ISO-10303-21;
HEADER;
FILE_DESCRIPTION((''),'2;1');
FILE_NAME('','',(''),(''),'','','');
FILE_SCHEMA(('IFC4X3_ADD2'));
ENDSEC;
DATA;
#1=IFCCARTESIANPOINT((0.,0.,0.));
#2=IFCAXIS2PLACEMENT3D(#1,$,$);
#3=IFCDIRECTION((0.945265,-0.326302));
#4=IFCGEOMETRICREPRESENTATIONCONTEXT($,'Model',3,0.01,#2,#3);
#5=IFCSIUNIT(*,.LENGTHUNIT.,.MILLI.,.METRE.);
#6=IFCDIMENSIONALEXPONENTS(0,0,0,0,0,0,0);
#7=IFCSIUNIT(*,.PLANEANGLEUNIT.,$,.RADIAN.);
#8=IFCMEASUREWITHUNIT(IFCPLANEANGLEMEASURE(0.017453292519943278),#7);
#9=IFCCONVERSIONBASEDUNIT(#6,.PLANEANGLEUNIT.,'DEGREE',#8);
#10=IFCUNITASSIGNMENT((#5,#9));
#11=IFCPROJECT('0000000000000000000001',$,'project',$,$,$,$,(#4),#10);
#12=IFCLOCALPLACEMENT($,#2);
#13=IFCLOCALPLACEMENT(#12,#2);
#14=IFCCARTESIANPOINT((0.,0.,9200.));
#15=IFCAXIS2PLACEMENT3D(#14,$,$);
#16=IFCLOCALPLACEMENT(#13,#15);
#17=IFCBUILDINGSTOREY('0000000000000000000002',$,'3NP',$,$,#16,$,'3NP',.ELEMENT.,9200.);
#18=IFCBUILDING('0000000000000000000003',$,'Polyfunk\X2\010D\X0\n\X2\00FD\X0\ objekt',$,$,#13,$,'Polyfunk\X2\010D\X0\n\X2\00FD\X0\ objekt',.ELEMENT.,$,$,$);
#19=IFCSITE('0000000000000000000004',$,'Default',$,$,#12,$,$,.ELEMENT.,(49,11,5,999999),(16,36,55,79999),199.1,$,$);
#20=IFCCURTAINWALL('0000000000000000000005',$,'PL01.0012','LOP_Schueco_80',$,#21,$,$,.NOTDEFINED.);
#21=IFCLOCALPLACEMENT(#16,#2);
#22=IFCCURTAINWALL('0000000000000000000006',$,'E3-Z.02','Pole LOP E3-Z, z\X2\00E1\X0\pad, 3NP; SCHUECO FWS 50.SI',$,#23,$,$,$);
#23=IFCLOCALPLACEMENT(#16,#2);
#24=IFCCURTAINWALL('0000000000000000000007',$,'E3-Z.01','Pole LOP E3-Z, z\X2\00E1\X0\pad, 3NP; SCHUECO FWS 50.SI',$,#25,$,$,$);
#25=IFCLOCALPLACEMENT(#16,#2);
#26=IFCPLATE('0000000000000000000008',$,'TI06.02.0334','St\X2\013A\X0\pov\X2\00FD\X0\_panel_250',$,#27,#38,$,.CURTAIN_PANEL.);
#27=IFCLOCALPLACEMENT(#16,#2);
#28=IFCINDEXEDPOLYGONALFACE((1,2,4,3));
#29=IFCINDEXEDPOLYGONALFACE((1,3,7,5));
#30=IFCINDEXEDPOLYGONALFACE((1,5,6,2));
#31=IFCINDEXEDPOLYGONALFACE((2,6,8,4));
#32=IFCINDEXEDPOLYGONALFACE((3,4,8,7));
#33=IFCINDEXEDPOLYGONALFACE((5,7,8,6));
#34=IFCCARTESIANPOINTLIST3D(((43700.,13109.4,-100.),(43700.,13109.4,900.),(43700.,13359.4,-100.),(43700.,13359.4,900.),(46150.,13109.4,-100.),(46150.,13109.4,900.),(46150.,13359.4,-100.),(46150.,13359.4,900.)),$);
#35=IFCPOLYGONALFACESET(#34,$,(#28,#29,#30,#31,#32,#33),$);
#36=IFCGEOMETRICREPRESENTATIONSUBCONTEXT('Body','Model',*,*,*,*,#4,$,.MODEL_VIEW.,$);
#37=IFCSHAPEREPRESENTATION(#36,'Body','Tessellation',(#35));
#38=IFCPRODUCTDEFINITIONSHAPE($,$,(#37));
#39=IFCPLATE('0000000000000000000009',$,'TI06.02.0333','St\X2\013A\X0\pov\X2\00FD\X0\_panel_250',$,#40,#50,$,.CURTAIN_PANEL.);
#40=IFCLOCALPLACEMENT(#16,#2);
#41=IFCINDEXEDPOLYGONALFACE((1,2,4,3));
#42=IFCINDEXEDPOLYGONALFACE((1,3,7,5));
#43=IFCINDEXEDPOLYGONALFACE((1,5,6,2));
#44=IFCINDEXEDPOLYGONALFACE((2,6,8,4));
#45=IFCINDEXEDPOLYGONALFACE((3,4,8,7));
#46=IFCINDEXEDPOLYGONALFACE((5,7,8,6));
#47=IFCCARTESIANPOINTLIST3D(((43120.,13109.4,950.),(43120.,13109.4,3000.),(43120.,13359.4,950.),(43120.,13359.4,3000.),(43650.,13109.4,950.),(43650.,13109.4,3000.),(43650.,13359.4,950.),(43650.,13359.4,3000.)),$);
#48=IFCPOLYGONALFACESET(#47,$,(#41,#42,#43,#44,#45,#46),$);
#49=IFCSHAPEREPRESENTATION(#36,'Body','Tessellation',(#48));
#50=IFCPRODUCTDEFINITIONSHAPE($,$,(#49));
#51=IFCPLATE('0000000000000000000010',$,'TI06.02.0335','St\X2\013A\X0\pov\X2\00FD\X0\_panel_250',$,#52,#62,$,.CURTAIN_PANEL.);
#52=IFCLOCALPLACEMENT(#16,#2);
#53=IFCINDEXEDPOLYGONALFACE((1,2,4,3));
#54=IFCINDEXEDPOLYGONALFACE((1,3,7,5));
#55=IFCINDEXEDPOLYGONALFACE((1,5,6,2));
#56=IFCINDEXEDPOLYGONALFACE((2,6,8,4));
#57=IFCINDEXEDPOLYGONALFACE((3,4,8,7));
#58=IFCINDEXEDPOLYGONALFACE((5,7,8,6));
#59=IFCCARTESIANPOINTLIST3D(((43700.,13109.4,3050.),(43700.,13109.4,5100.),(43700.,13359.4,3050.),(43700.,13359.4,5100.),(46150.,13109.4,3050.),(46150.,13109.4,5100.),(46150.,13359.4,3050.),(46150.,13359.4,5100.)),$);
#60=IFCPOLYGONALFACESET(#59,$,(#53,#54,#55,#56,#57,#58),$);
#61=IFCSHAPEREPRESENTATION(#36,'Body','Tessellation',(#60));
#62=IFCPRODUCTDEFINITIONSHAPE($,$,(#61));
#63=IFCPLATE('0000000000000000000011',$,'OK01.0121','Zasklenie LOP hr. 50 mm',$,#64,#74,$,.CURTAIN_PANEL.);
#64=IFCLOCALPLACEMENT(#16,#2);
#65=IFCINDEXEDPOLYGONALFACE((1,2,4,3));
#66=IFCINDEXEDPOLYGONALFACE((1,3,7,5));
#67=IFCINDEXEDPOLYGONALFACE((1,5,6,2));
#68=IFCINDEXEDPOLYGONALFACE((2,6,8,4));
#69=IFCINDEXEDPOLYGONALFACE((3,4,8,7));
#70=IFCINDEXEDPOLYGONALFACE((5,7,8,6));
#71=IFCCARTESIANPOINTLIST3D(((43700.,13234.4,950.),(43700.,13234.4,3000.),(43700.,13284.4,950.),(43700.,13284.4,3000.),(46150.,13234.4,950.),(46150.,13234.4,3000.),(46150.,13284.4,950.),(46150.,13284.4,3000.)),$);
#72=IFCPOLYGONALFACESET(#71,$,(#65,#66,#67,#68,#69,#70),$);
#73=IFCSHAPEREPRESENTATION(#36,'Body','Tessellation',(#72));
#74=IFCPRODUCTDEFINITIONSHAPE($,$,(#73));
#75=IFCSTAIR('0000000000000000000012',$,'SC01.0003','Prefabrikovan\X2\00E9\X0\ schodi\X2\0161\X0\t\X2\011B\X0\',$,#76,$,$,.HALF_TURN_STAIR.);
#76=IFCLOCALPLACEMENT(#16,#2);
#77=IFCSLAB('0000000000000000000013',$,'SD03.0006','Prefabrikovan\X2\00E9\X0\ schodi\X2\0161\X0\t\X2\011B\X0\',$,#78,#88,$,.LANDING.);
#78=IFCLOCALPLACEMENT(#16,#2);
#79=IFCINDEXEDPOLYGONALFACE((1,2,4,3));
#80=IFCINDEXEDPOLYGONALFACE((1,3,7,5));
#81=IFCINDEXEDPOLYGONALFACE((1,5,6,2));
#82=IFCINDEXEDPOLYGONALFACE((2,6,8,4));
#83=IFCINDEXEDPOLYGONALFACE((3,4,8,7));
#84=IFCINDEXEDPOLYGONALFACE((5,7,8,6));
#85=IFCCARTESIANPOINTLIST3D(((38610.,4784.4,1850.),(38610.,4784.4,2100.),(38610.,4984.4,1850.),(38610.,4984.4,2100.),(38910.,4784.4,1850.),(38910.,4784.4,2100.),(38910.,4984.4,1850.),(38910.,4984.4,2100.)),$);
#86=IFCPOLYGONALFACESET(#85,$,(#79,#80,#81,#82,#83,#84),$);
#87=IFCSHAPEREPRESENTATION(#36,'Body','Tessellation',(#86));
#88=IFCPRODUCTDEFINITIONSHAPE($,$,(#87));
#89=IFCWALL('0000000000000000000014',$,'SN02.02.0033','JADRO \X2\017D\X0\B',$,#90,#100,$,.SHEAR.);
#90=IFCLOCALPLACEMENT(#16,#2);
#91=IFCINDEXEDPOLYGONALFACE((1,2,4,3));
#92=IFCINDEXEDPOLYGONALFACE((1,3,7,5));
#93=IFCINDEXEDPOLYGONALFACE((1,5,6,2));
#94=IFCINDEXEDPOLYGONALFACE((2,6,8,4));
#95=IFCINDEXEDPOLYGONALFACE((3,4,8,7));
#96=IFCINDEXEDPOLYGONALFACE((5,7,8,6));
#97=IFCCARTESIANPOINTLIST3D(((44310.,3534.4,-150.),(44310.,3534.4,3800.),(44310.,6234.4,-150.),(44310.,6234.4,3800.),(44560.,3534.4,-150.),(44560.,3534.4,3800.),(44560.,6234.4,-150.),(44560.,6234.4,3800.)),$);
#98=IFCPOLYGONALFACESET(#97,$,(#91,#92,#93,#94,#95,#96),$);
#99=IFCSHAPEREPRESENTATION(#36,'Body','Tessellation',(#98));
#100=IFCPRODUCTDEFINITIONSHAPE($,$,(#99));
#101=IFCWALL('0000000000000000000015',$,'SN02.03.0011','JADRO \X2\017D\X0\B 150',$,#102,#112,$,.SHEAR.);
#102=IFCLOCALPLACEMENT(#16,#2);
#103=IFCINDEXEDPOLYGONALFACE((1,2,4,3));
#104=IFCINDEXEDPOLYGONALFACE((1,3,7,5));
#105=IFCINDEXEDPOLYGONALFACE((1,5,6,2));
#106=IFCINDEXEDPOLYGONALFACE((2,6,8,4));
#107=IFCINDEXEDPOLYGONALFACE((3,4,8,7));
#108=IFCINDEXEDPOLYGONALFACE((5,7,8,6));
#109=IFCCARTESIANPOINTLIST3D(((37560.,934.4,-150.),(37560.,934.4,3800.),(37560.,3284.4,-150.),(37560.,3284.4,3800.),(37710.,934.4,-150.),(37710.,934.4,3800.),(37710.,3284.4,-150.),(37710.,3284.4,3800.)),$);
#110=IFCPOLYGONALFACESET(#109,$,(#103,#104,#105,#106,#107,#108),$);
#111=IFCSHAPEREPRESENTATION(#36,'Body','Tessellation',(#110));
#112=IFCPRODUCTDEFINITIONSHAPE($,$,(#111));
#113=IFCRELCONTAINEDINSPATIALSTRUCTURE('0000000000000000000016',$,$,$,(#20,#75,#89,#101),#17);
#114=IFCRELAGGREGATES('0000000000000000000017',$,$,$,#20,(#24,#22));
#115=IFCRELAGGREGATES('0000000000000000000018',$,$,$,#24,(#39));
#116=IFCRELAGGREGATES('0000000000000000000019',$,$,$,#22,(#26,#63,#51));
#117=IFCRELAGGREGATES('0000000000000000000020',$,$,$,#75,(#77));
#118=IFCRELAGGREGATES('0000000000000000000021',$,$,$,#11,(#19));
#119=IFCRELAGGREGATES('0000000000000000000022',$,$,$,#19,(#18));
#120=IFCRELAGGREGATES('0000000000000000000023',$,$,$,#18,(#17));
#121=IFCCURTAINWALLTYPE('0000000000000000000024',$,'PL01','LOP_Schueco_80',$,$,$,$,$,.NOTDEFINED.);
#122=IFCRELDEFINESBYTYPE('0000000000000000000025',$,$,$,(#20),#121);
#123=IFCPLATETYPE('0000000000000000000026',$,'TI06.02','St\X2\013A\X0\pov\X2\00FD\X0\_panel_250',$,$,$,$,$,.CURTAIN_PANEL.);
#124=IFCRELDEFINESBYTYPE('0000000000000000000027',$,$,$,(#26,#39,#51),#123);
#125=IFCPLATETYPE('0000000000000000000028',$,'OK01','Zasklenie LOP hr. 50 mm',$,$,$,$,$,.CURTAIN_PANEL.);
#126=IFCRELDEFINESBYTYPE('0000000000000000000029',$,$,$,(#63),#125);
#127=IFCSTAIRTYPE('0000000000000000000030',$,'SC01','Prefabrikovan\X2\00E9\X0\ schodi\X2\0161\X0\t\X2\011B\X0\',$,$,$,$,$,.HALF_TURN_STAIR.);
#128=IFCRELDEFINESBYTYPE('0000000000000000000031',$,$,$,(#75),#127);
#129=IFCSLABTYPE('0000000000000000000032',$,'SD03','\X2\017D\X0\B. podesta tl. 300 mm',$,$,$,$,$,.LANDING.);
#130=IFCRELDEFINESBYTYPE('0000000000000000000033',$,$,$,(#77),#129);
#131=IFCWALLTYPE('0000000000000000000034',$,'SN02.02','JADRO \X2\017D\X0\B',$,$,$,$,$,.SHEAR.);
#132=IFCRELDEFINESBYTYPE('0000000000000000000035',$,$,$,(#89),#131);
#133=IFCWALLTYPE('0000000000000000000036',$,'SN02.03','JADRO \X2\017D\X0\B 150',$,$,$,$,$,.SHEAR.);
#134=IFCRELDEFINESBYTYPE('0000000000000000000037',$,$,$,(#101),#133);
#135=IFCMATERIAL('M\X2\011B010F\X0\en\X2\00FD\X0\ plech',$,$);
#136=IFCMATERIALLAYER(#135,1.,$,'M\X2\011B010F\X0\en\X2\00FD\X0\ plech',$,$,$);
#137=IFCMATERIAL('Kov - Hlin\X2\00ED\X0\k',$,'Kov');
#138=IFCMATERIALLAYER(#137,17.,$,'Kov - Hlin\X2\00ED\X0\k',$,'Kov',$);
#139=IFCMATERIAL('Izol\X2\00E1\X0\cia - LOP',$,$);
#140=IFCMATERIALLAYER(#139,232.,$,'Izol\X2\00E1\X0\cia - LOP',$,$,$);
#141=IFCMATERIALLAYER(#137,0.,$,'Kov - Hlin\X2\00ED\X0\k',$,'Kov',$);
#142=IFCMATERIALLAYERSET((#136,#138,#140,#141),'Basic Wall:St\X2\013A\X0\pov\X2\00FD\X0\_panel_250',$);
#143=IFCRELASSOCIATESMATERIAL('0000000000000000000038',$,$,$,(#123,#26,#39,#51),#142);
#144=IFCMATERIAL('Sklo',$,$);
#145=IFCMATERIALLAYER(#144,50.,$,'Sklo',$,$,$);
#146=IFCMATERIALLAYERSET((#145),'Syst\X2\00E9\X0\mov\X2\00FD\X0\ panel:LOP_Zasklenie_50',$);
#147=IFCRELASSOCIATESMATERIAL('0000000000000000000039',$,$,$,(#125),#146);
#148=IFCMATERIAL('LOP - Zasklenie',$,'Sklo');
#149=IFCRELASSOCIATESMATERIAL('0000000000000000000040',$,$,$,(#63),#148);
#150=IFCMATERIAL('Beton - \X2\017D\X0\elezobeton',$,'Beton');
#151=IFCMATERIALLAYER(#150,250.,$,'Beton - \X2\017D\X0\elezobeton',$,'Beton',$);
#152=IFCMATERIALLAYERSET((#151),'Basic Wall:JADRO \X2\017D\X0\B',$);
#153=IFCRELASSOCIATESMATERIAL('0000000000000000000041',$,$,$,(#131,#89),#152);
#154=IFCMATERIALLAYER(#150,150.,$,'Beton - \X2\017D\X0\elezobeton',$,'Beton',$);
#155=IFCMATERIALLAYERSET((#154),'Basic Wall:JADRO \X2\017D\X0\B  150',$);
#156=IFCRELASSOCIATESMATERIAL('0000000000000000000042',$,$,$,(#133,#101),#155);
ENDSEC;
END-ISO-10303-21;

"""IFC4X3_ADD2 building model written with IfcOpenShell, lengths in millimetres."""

from ifc_helpers import new_model, entity, si_unit, converted_unit, direction, frame, frame_2d, origin, origin_2d_with_axis, place, context, subcontext, project, spatial, polyline, rectangle, extrude, clip, bounded_halfspace, source, transform, mapped, material, layer, layer_set, layer_usage, type_object, type_shapes, element, aggregate, save


model = new_model("IFC4X3_ADD2")

# Units and contexts
model_context = context("Model", 3, precision=0.01, world=origin(), true_north=direction((0.945265, -0.326302)))
body_context = subcontext(model_context, "Body", "Model", "MODEL_VIEW")
ifc_project = project(units=[si_unit("LENGTHUNIT", "METRE", prefix="MILLI"), converted_unit("PLANEANGLEUNIT", "DEGREE", entity("IfcPlaneAngleMeasure", 0.017453292519943278), si_unit("PLANEANGLEUNIT", "RADIAN"), dimensions=[0, 0, 0, 0, 0, 0, 0])], contexts=[model_context])

# Site, building, storey
site_placement = place(None, origin())
site = spatial("IfcSite", under=ifc_project, at=site_placement, Name="Default", CompositionType="ELEMENT", RefLatitude=(49, 11, 5, 999999), RefLongitude=(16, 36, 55, 79999), RefElevation=199.1)
building_placement = place(site_placement, origin())
building = spatial("IfcBuilding", under=site, at=building_placement, Name="Polyfunkčný objekt", LongName="Polyfunkčný objekt", CompositionType="ELEMENT")
storey_placement = place(building_placement, frame((0.0, 0.0, 9200.0)))
storey = spatial("IfcBuildingStorey", under=building, at=storey_placement, Name="3NP", LongName="3NP", CompositionType="ELEMENT", Elevation=9200.0)

# Curtain walls, plates
curtain_wall_type = type_object("IfcCurtainWallType", Name="PL01", Description="LOP_Schueco_80", PredefinedType="NOTDEFINED")
curtain_wall_1_placement = place(storey_placement, frame((0.0, 0.0, -9200.0)))
curtain_wall_1 = element("IfcCurtainWall", 1, at=curtain_wall_1_placement, inside=storey, type_object=curtain_wall_type, Name="PL01.0012", Description="LOP_Schueco_80", PredefinedType="NOTDEFINED")
curtain_wall_2 = element("IfcCurtainWall", 2, Name="E3-Z.02", Description="Pole LOP E3-Z, západ, 3NP; SCHUECO FWS 50.SI")
curtain_wall_3 = element("IfcCurtainWall", 3, Name="E3-Z.01", Description="Pole LOP E3-Z, západ, 3NP; SCHUECO FWS 50.SI")
aggregate(curtain_wall_1, [curtain_wall_3, curtain_wall_2])
ifc_material_1 = material(Name="Měďený plech")
ifc_layer_1 = layer(ifc_material_1, 1.0, Name="Měďený plech")
ifc_material_2 = material(Name="Kov - Hliník", Category="Kov")
ifc_layer_2 = layer(ifc_material_2, 17.0, Name="Kov - Hliník", Category="Kov")
ifc_material_3 = material(Name="Izolácia - LOP")
ifc_layer_3 = layer(ifc_material_3, 232.0, Name="Izolácia - LOP")
ifc_layer_4 = layer(ifc_material_2, 0.0, Name="Kov - Hliník", Category="Kov")
ifc_layer_set_1 = layer_set([ifc_layer_1, ifc_layer_2, ifc_layer_3, ifc_layer_4], Name="Basic Wall:Stĺpový_panel_250")
ifc_layer_usage_1 = layer_usage(ifc_layer_set_1, "AXIS2", "NEGATIVE", 125.0)
plate_type_1 = type_object("IfcPlateType", Name="TI06.02", Description="Stĺpový_panel_250", PredefinedType="CURTAIN_PANEL", material=ifc_layer_set_1)
plate_1_placement = place(storey_placement, frame((43700.0, 13234.4, -100.0)))
plate_1 = element("IfcPlate", 4, at=plate_1_placement, type_object=plate_type_1, material=ifc_layer_usage_1, Name="TI06.02.0334", Description="Stĺpový_panel_250", PredefinedType="CURTAIN_PANEL", context=body_context, shape_type="SweptSolid", body=[
    extrude(rectangle(XDim=250.0, YDim=2450.0, at=frame_2d((0.0, 0.0), x_axis=(1.0, 0.0))), frame((1225.0, 0.0, 0.0), z_axis=(0.0, 0.0, 1.0), x_axis=(0.0, 1.0, 0.0)), (0.0, 0.0, 1.0), 1000.0),
])
ifc_layer_usage_2 = layer_usage(ifc_layer_set_1, "AXIS2", "NEGATIVE", 125.0)
plate_2_placement = place(storey_placement, frame((43120.0, 13234.4, 950.0)))
plate_2 = element("IfcPlate", 5, at=plate_2_placement, type_object=plate_type_1, material=ifc_layer_usage_2, Name="TI06.02.0333", Description="Stĺpový_panel_250", PredefinedType="CURTAIN_PANEL", context=body_context, shape_type="SweptSolid", body=[
    extrude(rectangle(XDim=250.0, YDim=530.0, at=frame_2d((0.0, 0.0), x_axis=(1.0, 0.0))), frame((265.0, 0.0, 0.0), z_axis=(0.0, 0.0, 1.0), x_axis=(0.0, 1.0, 0.0)), (0.0, 0.0, 1.0), 2050.0),
])
aggregate(curtain_wall_3, [plate_2])
ifc_layer_usage_3 = layer_usage(ifc_layer_set_1, "AXIS2", "NEGATIVE", 125.0)
plate_3_placement = place(storey_placement, frame((43700.0, 13234.4, 3050.0)))
plate_3 = element("IfcPlate", 6, at=plate_3_placement, type_object=plate_type_1, material=ifc_layer_usage_3, Name="TI06.02.0335", Description="Stĺpový_panel_250", PredefinedType="CURTAIN_PANEL", context=body_context, shape_type="SweptSolid", body=[
    extrude(rectangle(XDim=250.0, YDim=2450.0, at=frame_2d((0.0, 0.0), x_axis=(1.0, 0.0))), frame((1225.0, 0.0, 0.0), z_axis=(0.0, 0.0, 1.0), x_axis=(0.0, 1.0, 0.0)), (0.0, 0.0, 1.0), 2050.0),
])
ifc_material_4 = material(Name="LOP - Zasklenie", Category="Sklo")
ifc_material_5 = material(Name="Sklo")
ifc_layer_5 = layer(ifc_material_5, 50.0, Name="Sklo")
ifc_layer_set_2 = layer_set([ifc_layer_5], Name="Systémový panel:LOP_Zasklenie_50")
plate_type_2 = type_object("IfcPlateType", Name="OK01", Description="Zasklenie LOP hr. 50 mm", PredefinedType="CURTAIN_PANEL", material=ifc_layer_set_2)
shared_shape_1 = source(origin(), body_context, "Body", "SweptSolid", [
    extrude(rectangle(XDim=50.0, YDim=2450.0, at=origin_2d_with_axis()), frame((0.0, 25.0, 0.0), z_axis=(0.0, 0.0, 1.0), x_axis=(0.0, 1.0, 0.0)), (0.0, 0.0, 1.0), 2050.0),
])
type_shapes(plate_type_2, [shared_shape_1])
plate_4_placement = place(curtain_wall_1_placement, frame((44925.0, 13234.4, 10150.0)))
plate_4 = element("IfcPlate", 7, at=plate_4_placement, type_object=plate_type_2, material=ifc_material_4, Name="OK01.0121", Description="Zasklenie LOP hr. 50 mm", PredefinedType="CURTAIN_PANEL", context=body_context, shape_type="MappedRepresentation", body=[
    mapped(shared_shape_1, transform((0.0, 0.0, 0.0), scale=1.0)),
])
aggregate(curtain_wall_2, [plate_1, plate_4, plate_3])

# Stair, slab
stair_type = type_object("IfcStairType", Name="SC01", Description="Prefabrikované schodiště", PredefinedType="HALF_TURN_STAIR")
stair_placement = place(storey_placement, origin())
stair = element("IfcStair", 8, at=stair_placement, inside=storey, type_object=stair_type, Name="SC01.0003", Description="Prefabrikované schodiště", PredefinedType="HALF_TURN_STAIR")
slab_type = type_object("IfcSlabType", Name="SD03", Description="ŽB. podesta tl. 300 mm", PredefinedType="LANDING")
slab_placement = place(stair_placement, frame((38610.0, 4784.4, 0.0)))
slab = element("IfcSlab", 9, at=slab_placement, type_object=slab_type, Name="SD03.0006", Description="Prefabrikované schodiště", PredefinedType="LANDING", context=body_context, shape_type="SweptSolid", body=[
    extrude(rectangle(XDim=200.0, YDim=300.0, at=frame_2d((0.0, 0.0), x_axis=(1.0, 0.0))), frame((150.0, 100.0, 1850.0), z_axis=(0.0, 0.0, 1.0), x_axis=(0.0, 1.0, 0.0)), (0.0, 0.0, 1.0), 250.0),
])
aggregate(stair, [slab])

# Walls
ifc_material_6 = material(Name="Beton - Železobeton", Category="Beton")
ifc_layer_6 = layer(ifc_material_6, 250.0, Name="Beton - Železobeton", Category="Beton")
ifc_layer_set_3 = layer_set([ifc_layer_6], Name="Basic Wall:JADRO ŽB")
wall_type_1 = type_object("IfcWallType", Name="SN02.02", Description="JADRO ŽB", PredefinedType="SHEAR", material=ifc_layer_set_3)
placement = place(building_placement, frame((0.0, 0.0, 5000.0)))
wall_1_placement = place(placement, frame((44435.0, 6234.4, 4050.0), z_axis=(0.0, 0.0, 1.0), x_axis=(0.0, -1.0, 0.0)))
element("IfcWall", 10, at=wall_1_placement, inside=storey, type_object=wall_type_1, material=ifc_layer_set_3, Name="SN02.02.0033", Description="JADRO ŽB", PredefinedType="SHEAR", context=body_context, shape_type="Clipping", body=[
    clip(clip(extrude(rectangle(XDim=2700.0, YDim=250.0, at=frame_2d((1350.0, 0.0), x_axis=(-1.0, 0.0))), origin(), (0.0, 0.0, 1.0), 3950.0), bounded_halfspace(frame((2700.0, -125.0, 0.0), z_axis=(0.0, 0.0, 1.0), x_axis=(0.0, -1.0, 0.0)), True, frame((2700.0, -125.0, 0.0)), polyline([(0.0, 0.0), (0.0, 250.0), (-2700.0, 250.0), (-2700.0, 0.0), (0.0, 0.0)]))), bounded_halfspace(frame((0.0, -125.0, 3950.0), z_axis=(0.0, 0.0, -1.0), x_axis=(0.0, 1.0, 0.0)), True, frame((0.0, -125.0, 3950.0)), polyline([(0.0, 0.0), (2700.0, 0.0), (2700.0, 250.0), (0.0, 250.0), (0.0, 0.0)]))),
])
ifc_layer_7 = layer(ifc_material_6, 150.0, Name="Beton - Železobeton", Category="Beton")
ifc_layer_set_4 = layer_set([ifc_layer_7], Name="Basic Wall:JADRO ŽB  150")
wall_type_2 = type_object("IfcWallType", Name="SN02.03", Description="JADRO ŽB 150", PredefinedType="SHEAR", material=ifc_layer_set_4)
wall_2_placement = place(placement, frame((37635.0, 3284.4, 4050.0), z_axis=(0.0, 0.0, 1.0), x_axis=(0.0, -1.0, 0.0)))
element("IfcWall", 11, at=wall_2_placement, inside=storey, type_object=wall_type_2, material=ifc_layer_set_4, Name="SN02.03.0011", Description="JADRO ŽB 150", PredefinedType="SHEAR", context=body_context, shape_type="SweptSolid", body=[
    extrude(rectangle(XDim=2350.0, YDim=150.0, at=frame_2d((1175.0, 0.0), x_axis=(-1.0, 0.0))), origin(), (0.0, 0.0, 1.0), 3950.0),
])

save(model, "model.ifc")
